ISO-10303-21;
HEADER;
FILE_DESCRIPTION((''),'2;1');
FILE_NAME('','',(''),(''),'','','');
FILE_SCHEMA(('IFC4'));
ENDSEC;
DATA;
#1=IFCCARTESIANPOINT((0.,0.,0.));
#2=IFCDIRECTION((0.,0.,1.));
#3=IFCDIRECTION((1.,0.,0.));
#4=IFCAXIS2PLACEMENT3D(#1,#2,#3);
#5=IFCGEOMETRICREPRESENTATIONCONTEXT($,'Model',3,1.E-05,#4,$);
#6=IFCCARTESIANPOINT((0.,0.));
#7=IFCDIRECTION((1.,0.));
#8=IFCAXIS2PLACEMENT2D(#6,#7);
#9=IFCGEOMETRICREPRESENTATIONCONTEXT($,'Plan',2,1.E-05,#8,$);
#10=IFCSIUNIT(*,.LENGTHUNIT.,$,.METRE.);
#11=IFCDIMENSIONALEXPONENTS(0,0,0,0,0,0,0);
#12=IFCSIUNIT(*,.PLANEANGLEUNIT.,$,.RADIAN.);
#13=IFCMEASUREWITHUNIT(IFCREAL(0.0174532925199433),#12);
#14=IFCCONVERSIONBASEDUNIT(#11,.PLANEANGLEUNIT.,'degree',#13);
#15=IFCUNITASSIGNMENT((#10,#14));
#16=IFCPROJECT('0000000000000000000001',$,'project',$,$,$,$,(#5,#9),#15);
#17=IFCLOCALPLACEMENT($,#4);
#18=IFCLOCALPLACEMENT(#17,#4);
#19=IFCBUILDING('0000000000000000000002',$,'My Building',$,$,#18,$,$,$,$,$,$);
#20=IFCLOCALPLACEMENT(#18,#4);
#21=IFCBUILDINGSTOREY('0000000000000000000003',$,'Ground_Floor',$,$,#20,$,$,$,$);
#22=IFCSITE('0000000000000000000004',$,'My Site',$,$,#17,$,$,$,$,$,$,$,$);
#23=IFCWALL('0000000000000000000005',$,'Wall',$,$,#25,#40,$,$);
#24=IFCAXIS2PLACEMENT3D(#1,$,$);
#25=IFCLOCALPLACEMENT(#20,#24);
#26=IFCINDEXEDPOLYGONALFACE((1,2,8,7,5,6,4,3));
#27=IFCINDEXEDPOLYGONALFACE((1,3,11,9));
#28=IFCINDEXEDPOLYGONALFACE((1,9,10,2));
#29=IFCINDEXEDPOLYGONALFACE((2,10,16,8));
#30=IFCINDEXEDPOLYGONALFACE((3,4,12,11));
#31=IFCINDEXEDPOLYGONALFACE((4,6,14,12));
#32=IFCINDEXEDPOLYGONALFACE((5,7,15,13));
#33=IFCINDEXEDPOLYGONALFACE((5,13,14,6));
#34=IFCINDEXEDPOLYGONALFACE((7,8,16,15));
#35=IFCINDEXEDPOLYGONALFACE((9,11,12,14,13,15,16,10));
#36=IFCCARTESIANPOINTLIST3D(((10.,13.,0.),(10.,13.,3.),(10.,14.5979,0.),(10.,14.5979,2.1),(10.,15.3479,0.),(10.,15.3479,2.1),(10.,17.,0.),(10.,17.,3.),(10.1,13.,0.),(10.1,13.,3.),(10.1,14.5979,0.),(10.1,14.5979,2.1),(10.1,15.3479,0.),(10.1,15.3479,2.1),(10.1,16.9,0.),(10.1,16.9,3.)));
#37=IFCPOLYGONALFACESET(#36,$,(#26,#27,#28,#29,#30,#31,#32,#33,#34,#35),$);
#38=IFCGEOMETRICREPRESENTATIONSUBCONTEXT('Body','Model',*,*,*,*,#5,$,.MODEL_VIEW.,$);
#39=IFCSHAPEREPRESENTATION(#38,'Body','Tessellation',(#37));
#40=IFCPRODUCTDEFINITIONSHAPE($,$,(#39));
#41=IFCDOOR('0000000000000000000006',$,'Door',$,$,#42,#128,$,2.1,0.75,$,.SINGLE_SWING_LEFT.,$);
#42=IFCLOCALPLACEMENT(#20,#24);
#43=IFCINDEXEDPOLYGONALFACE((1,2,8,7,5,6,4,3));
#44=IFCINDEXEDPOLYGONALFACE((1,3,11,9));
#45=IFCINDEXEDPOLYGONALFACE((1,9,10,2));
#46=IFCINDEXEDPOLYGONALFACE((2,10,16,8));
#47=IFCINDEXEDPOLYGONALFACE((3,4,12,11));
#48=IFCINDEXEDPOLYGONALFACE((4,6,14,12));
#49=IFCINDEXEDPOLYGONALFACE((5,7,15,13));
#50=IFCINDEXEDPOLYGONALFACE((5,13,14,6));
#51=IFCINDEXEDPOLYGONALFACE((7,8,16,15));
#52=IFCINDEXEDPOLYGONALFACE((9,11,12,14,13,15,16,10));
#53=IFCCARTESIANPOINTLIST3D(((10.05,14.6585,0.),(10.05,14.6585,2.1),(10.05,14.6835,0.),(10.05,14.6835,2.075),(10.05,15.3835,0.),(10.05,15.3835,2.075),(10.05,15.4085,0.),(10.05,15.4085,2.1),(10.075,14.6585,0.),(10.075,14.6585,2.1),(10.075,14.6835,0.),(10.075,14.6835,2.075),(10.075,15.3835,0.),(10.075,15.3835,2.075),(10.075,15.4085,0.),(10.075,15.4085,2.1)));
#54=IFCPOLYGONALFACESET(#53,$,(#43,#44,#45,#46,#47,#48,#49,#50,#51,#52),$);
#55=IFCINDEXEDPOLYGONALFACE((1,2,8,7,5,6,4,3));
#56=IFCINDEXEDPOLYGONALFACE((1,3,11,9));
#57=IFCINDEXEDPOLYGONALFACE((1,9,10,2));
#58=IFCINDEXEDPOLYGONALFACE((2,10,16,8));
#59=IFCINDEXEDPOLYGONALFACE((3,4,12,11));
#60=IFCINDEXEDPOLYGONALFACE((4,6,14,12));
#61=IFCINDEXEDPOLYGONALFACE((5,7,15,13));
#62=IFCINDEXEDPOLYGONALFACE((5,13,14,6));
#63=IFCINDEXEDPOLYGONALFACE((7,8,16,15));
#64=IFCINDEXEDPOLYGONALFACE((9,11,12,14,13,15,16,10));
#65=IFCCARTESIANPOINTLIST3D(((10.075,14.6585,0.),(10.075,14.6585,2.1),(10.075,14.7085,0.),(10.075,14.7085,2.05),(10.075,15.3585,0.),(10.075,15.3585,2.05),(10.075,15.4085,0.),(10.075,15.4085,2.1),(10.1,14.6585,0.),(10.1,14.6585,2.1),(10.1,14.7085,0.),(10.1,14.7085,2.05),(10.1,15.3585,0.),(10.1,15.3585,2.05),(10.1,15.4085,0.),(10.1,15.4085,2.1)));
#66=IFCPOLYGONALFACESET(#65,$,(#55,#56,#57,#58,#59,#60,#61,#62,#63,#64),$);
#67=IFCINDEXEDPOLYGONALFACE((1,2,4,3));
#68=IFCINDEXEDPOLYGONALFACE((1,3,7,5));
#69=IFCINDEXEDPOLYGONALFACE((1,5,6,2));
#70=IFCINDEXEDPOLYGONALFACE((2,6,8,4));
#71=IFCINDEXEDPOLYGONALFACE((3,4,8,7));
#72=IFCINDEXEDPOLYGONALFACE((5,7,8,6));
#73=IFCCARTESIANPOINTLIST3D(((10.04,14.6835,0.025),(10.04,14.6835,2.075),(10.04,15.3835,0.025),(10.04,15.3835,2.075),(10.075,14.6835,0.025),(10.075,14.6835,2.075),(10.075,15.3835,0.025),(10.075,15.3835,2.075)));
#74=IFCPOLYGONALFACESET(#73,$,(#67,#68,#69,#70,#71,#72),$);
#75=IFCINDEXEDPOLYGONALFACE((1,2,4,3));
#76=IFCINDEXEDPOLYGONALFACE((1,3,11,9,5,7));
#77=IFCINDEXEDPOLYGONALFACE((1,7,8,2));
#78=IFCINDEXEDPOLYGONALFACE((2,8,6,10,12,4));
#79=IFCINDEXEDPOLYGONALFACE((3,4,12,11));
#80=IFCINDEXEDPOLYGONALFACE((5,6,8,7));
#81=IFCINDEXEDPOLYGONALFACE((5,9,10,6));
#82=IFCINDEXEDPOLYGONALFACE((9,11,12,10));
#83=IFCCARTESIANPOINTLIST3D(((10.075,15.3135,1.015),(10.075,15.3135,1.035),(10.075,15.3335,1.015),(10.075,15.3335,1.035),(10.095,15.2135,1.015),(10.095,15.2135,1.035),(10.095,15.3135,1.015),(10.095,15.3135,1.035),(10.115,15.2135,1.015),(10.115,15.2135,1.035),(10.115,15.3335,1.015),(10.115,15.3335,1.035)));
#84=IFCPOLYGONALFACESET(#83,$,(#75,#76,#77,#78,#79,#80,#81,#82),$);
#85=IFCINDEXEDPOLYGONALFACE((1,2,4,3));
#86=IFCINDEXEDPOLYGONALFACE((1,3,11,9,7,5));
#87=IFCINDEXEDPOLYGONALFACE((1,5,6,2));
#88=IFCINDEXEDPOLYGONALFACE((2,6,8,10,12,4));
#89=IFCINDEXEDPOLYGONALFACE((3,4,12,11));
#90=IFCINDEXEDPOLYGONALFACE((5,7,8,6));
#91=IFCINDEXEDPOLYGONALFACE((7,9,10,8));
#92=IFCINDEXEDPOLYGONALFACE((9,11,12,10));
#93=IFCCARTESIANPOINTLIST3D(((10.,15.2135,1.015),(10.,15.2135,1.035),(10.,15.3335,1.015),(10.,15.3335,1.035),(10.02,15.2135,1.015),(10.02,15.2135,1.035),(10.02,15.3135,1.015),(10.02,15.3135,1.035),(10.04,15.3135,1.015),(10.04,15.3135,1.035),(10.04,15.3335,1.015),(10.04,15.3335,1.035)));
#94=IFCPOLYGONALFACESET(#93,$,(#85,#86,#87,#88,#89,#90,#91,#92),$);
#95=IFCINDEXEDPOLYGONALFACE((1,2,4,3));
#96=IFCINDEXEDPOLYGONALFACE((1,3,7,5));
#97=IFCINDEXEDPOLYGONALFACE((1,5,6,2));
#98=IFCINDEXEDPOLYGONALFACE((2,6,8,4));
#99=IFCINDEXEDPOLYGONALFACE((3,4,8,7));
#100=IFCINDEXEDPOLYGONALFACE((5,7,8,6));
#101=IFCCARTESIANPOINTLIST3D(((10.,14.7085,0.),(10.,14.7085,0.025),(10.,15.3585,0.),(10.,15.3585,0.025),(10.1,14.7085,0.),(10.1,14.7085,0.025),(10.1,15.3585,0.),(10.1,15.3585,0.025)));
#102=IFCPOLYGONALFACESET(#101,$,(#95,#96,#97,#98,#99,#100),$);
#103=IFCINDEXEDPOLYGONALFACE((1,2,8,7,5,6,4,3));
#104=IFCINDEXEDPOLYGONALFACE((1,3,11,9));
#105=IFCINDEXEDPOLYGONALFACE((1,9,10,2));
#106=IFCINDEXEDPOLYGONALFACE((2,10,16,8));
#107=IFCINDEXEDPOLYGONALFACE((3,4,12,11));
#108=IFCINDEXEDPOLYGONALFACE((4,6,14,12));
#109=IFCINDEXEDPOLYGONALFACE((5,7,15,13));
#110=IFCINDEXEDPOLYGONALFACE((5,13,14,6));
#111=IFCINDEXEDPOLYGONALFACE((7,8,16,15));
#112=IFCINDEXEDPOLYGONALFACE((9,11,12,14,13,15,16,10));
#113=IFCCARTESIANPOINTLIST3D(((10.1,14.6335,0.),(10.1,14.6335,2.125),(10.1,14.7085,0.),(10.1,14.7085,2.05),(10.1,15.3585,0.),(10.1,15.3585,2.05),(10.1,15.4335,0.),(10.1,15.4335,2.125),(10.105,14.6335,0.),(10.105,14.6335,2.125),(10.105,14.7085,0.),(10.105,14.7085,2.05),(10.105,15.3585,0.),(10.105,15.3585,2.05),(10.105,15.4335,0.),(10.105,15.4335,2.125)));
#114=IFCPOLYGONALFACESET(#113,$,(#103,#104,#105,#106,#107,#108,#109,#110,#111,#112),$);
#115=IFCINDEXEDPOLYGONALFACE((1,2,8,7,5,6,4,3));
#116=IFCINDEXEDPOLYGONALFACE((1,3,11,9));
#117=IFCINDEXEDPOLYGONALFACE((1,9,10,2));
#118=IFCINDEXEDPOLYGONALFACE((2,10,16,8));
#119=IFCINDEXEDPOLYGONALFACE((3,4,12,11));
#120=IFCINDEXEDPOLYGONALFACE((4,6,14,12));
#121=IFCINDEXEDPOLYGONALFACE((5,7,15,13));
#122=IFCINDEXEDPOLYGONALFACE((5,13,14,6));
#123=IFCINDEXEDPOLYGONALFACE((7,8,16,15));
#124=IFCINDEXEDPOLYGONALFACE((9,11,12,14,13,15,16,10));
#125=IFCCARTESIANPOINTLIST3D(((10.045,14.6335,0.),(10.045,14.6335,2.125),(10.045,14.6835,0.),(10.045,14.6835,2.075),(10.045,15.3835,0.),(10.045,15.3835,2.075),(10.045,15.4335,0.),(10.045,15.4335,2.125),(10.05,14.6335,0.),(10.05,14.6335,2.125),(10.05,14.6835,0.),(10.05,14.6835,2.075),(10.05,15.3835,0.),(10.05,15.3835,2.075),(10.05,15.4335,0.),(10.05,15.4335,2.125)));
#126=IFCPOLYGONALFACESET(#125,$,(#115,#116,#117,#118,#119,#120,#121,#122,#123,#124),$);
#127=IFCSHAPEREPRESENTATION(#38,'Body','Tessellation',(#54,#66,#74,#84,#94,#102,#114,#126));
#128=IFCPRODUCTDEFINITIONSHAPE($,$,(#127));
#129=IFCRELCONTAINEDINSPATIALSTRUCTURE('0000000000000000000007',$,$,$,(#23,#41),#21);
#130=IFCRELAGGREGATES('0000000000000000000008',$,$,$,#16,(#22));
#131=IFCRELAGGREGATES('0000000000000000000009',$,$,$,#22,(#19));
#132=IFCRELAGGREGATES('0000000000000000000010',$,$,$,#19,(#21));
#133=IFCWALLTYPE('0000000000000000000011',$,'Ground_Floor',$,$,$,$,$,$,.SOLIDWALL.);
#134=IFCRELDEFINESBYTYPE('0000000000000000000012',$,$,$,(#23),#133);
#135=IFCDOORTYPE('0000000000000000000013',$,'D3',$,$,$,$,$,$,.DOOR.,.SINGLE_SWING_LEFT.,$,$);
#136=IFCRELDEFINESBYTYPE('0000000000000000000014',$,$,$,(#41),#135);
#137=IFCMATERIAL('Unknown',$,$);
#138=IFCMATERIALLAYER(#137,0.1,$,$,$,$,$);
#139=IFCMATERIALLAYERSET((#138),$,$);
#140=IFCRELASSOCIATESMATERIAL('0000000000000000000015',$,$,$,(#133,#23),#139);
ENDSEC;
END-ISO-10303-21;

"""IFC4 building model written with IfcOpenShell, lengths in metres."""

from ifc_helpers import new_model, entity, si_unit, converted_unit, frame, origin_with_axes, origin_2d_with_axis, place, context, subcontext, project, spatial, line, indexed_curve, outline, extrude, shape, source, transform, mapped, material, layer, layer_set, layer_usage, type_object, type_shapes, element, fill, save


model = new_model("IFC4")

# Units and contexts
model_context = context("Model", 3, precision=1e-05, world=origin_with_axes())
plan_context = context("Plan", 2, precision=1e-05, world=origin_2d_with_axis())
body_context_1 = subcontext(model_context, "Body", "Model", "MODEL_VIEW")
body_context_2 = subcontext(plan_context, "Body", "Plan", "PLAN_VIEW")
ifc_project = project(units=[si_unit("LENGTHUNIT", "METRE"), converted_unit("PLANEANGLEUNIT", "degree", entity("IfcReal", 0.0174532925199433), si_unit("PLANEANGLEUNIT", "RADIAN"), dimensions=[0, 0, 0, 0, 0, 0, 0])], contexts=[model_context, plan_context])

# Site, building, storey
site_placement = place(None, origin_with_axes())
site = spatial("IfcSite", under=ifc_project, at=site_placement, Name="My Site")
building_placement = place(site_placement, origin_with_axes())
building = spatial("IfcBuilding", under=site, at=building_placement, Name="My Building")
storey_placement = place(building_placement, origin_with_axes())
storey = spatial("IfcBuildingStorey", under=building, at=storey_placement, Name="Ground_Floor")

# Shared definitions
ifc_material = material(Name="Unknown")

# Shared definitions
ifc_layer_1 = layer(ifc_material, 0.1)
ifc_layer_set_1 = layer_set([ifc_layer_1])
wall_type = type_object("IfcWallType", Name="Ground_Floor", PredefinedType="SOLIDWALL", material=ifc_layer_set_1)

# Wall, opening, door
ifc_layer_usage_1 = layer_usage(ifc_layer_set_1, "AXIS2", "POSITIVE", 0.0)
wall_1_placement = place(storey_placement, frame((10.0, 17.0, 0.0), z_axis=(0.0, 0.0, 1.0), x_axis=(0.0, -1.0, 0.0)))
wall_1 = element("IfcWall", 1, at=wall_1_placement, inside=storey, type_object=wall_type, material=ifc_layer_usage_1, Name="Wall", context=body_context_1, shape_type="SweptSolid", body=[
    extrude(outline(indexed_curve([(0.0, 0.0), (0.1, 0.1), (4.0, 0.1), (4.0, 0.0)], segments=[line(1, 2, 3, 4, 1)])), origin_with_axes(), (0.0, 0.0, 1.0), 3.0),
])
shared_shape_1 = source(origin_with_axes(), body_context_1, "Body", "SweptSolid", [
    extrude(outline(indexed_curve([(0.0, 0.0), (0.75, 0.0), (0.75, 2.1), (0.0, 2.1)], segments=[line(1, 2, 3, 4, 1)])), frame((0.0, -0.6, 0.0), z_axis=(0.0, -1.0, 0.0), x_axis=(1.0, 0.0, 0.0)), (0.0, 0.0, -1.0), 1.2),
])
opening_1_placement = place(wall_1_placement, frame((2.4021, 0.1, 0.0), z_axis=(0.0, 0.0, 1.0), x_axis=(-1.0, 0.0, 0.0)))
opening_1 = element("IfcOpeningElement", 2, at=opening_1_placement, cuts=wall_1, PredefinedType="OPENING", context=body_context_1, shape_type="MappedRepresentation", body=[
    mapped(shared_shape_1, transform((0.0, 0.0, 0.0), x_axis=(1.0, 0.0, 0.0), y_axis=(0.0, 1.0, 0.0), z_axis=(0.0, 0.0, 1.0), scale=1.0)),
])
door_type_1 = type_object("IfcDoorType", Name="D3", OperationType="SINGLE_SWING_LEFT", PredefinedType="DOOR")
shared_shape_2 = source(origin_with_axes(), body_context_1, "Body", "SweptSolid", [
    extrude(outline(indexed_curve([(0.0, 0.0), (0.0, 2.1), (0.75, 2.1), (0.75, 0.0), (0.725, 0.0), (0.725, 2.075), (0.025, 2.075), (0.025, 0.0)], segments=[line(1, 2, 3, 4, 5, 6, 7, 8, 1)])), frame((0.0, 0.025, 0.0), z_axis=(0.0, -1.0, 0.0), x_axis=(1.0, 0.0, 0.0)), (0.0, 0.0, -1.0), 0.025),
    extrude(outline(indexed_curve([(0.0, 0.0), (0.0, 2.1), (0.75, 2.1), (0.75, 0.0), (0.7, 0.0), (0.7, 2.05), (0.05, 2.05), (0.05, 0.0)], segments=[line(1, 2, 3, 4, 5, 6, 7, 8, 1)])), frame((0.0, 0.0, 0.0), z_axis=(0.0, -1.0, 0.0), x_axis=(1.0, 0.0, 0.0)), (0.0, 0.0, -1.0), 0.025),
    extrude(outline(indexed_curve([(0.0, 0.0), (0.7, 0.0), (0.7, 0.035), (0.0, 0.035)], segments=[line(1, 2, 3, 4, 1)])), frame((0.025, 0.025, 0.025), z_axis=(0.0, 0.0, 1.0), x_axis=(1.0, 0.0, 0.0)), (0.0, 0.0, 1.0), 2.05),
    extrude(outline(indexed_curve([(0.0, 0.0), (0.0, -0.04), (-0.12, -0.04), (-0.12, -0.02), (-0.02, -0.02), (-0.02, 0.0)], segments=[line(1, 2, 3, 4, 5, 6, 1)])), frame((0.675, 0.025, 1.015), z_axis=(0.0, 0.0, 1.0), x_axis=(1.0, 0.0, 0.0)), (0.0, 0.0, 1.0), 0.02),
    extrude(outline(indexed_curve([(0.0, 0.0), (0.0, 0.04), (-0.12, 0.04), (-0.12, 0.02), (-0.02, 0.02), (-0.02, 0.0)], segments=[line(1, 2, 3, 4, 5, 6, 1)])), frame((0.675, 0.06, 1.015), z_axis=(0.0, 0.0, 1.0), x_axis=(1.0, 0.0, 0.0)), (0.0, 0.0, 1.0), 0.02),
    extrude(outline(indexed_curve([(0.0, 0.0), (0.65, 0.0), (0.65, 0.1), (0.0, 0.1)], segments=[line(1, 2, 3, 4, 1)])), frame((0.05, 0.0, 0.0), z_axis=(0.0, 0.0, 1.0), x_axis=(1.0, 0.0, 0.0)), (0.0, 0.0, 1.0), 0.025),
    extrude(outline(indexed_curve([(0.0, 0.0), (0.0, 2.125), (0.8, 2.125), (0.8, 0.0), (0.725, 0.0), (0.725, 2.05), (0.075, 2.05), (0.075, 0.0)], segments=[line(1, 2, 3, 4, 5, 6, 7, 8, 1)])), frame((-0.025, -0.005, 0.0), z_axis=(0.0, -1.0, 0.0), x_axis=(1.0, 0.0, 0.0)), (0.0, 0.0, -1.0), 0.005),
    extrude(outline(indexed_curve([(0.0, 0.0), (0.0, 2.125), (0.8, 2.125), (0.8, 0.0), (0.75, 0.0), (0.75, 2.075), (0.05, 2.075), (0.05, 0.0)], segments=[line(1, 2, 3, 4, 5, 6, 7, 8, 1)])), frame((-0.025, 0.05, 0.0), z_axis=(0.0, -1.0, 0.0), x_axis=(1.0, 0.0, 0.0)), (0.0, 0.0, -1.0), 0.005),
])
shared_shape_3 = source(origin_with_axes(), body_context_2, "Body", "Curve2D", [
    entity("IfcIndexedPolyCurve", entity("IfcCartesianPointList2D", [[0.0, 0.0], [0.0, 0.05], [0.025, 0.05], [0.025, 0.025], [0.05, 0.025], [0.05, 0.0]]), [entity("IfcLineIndex", [1, 2, 3, 4, 5, 6, 1])]),
    entity("IfcIndexedPolyCurve", entity("IfcCartesianPointList2D", [[0.75, 0.0], [0.75, 0.05], [0.725, 0.05], [0.725, 0.025], [0.7, 0.025], [0.7, 0.0]]), [entity("IfcLineIndex", [1, 2, 3, 4, 5, 6, 1])]),
    entity("IfcTrimmedCurve", entity("IfcEllipse", entity("IfcAxis2Placement2D", entity("IfcCartesianPoint", [0.06, 0.05]), entity("IfcDirection", [1.0, 0.0])), 0.665, 0.7), [entity("IfcCartesianPoint", [0.725, 0.05])], [entity("IfcCartesianPoint", [0.06, 0.75])], True, "CARTESIAN"),
    entity("IfcIndexedPolyCurve", entity("IfcCartesianPointList2D", [[0.025, 0.05], [0.06, 0.05], [0.06, 0.75], [0.025, 0.75]]), [entity("IfcLineIndex", [1, 2, 3, 4, 1])]),
])
type_shapes(door_type_1, [shared_shape_2, shared_shape_3])
door_1_placement = place(opening_1_placement, frame((0.0606, 0.0, 0.0), z_axis=(0.0, 0.0, 1.0), x_axis=(1.0, 0.0, 0.0)))
door_1 = element("IfcDoor", 3, at=door_1_placement, inside=storey, type_object=door_type_1, Name="Door", OperationType="SINGLE_SWING_LEFT", OverallHeight=2.1, OverallWidth=0.75, shapes=[
    shape(body_context_1, "Body", "MappedRepresentation", [mapped(shared_shape_2, transform((0.0, 0.0, 0.0), x_axis=(1.0, 0.0, 0.0), y_axis=(0.0, 1.0, 0.0), z_axis=(0.0, 0.0, 1.0), scale=1.0))]),
    shape(body_context_2, "Body", "MappedRepresentation", [mapped(shared_shape_3, transform((0.0, 0.0, 0.0), x_axis=(1.0, 0.0, 0.0), y_axis=(0.0, 1.0, 0.0), z_axis=(0.0, 0.0, 1.0), scale=1.0))]),
])
fill(opening_1, door_1)

save(model, "model.ifc")
